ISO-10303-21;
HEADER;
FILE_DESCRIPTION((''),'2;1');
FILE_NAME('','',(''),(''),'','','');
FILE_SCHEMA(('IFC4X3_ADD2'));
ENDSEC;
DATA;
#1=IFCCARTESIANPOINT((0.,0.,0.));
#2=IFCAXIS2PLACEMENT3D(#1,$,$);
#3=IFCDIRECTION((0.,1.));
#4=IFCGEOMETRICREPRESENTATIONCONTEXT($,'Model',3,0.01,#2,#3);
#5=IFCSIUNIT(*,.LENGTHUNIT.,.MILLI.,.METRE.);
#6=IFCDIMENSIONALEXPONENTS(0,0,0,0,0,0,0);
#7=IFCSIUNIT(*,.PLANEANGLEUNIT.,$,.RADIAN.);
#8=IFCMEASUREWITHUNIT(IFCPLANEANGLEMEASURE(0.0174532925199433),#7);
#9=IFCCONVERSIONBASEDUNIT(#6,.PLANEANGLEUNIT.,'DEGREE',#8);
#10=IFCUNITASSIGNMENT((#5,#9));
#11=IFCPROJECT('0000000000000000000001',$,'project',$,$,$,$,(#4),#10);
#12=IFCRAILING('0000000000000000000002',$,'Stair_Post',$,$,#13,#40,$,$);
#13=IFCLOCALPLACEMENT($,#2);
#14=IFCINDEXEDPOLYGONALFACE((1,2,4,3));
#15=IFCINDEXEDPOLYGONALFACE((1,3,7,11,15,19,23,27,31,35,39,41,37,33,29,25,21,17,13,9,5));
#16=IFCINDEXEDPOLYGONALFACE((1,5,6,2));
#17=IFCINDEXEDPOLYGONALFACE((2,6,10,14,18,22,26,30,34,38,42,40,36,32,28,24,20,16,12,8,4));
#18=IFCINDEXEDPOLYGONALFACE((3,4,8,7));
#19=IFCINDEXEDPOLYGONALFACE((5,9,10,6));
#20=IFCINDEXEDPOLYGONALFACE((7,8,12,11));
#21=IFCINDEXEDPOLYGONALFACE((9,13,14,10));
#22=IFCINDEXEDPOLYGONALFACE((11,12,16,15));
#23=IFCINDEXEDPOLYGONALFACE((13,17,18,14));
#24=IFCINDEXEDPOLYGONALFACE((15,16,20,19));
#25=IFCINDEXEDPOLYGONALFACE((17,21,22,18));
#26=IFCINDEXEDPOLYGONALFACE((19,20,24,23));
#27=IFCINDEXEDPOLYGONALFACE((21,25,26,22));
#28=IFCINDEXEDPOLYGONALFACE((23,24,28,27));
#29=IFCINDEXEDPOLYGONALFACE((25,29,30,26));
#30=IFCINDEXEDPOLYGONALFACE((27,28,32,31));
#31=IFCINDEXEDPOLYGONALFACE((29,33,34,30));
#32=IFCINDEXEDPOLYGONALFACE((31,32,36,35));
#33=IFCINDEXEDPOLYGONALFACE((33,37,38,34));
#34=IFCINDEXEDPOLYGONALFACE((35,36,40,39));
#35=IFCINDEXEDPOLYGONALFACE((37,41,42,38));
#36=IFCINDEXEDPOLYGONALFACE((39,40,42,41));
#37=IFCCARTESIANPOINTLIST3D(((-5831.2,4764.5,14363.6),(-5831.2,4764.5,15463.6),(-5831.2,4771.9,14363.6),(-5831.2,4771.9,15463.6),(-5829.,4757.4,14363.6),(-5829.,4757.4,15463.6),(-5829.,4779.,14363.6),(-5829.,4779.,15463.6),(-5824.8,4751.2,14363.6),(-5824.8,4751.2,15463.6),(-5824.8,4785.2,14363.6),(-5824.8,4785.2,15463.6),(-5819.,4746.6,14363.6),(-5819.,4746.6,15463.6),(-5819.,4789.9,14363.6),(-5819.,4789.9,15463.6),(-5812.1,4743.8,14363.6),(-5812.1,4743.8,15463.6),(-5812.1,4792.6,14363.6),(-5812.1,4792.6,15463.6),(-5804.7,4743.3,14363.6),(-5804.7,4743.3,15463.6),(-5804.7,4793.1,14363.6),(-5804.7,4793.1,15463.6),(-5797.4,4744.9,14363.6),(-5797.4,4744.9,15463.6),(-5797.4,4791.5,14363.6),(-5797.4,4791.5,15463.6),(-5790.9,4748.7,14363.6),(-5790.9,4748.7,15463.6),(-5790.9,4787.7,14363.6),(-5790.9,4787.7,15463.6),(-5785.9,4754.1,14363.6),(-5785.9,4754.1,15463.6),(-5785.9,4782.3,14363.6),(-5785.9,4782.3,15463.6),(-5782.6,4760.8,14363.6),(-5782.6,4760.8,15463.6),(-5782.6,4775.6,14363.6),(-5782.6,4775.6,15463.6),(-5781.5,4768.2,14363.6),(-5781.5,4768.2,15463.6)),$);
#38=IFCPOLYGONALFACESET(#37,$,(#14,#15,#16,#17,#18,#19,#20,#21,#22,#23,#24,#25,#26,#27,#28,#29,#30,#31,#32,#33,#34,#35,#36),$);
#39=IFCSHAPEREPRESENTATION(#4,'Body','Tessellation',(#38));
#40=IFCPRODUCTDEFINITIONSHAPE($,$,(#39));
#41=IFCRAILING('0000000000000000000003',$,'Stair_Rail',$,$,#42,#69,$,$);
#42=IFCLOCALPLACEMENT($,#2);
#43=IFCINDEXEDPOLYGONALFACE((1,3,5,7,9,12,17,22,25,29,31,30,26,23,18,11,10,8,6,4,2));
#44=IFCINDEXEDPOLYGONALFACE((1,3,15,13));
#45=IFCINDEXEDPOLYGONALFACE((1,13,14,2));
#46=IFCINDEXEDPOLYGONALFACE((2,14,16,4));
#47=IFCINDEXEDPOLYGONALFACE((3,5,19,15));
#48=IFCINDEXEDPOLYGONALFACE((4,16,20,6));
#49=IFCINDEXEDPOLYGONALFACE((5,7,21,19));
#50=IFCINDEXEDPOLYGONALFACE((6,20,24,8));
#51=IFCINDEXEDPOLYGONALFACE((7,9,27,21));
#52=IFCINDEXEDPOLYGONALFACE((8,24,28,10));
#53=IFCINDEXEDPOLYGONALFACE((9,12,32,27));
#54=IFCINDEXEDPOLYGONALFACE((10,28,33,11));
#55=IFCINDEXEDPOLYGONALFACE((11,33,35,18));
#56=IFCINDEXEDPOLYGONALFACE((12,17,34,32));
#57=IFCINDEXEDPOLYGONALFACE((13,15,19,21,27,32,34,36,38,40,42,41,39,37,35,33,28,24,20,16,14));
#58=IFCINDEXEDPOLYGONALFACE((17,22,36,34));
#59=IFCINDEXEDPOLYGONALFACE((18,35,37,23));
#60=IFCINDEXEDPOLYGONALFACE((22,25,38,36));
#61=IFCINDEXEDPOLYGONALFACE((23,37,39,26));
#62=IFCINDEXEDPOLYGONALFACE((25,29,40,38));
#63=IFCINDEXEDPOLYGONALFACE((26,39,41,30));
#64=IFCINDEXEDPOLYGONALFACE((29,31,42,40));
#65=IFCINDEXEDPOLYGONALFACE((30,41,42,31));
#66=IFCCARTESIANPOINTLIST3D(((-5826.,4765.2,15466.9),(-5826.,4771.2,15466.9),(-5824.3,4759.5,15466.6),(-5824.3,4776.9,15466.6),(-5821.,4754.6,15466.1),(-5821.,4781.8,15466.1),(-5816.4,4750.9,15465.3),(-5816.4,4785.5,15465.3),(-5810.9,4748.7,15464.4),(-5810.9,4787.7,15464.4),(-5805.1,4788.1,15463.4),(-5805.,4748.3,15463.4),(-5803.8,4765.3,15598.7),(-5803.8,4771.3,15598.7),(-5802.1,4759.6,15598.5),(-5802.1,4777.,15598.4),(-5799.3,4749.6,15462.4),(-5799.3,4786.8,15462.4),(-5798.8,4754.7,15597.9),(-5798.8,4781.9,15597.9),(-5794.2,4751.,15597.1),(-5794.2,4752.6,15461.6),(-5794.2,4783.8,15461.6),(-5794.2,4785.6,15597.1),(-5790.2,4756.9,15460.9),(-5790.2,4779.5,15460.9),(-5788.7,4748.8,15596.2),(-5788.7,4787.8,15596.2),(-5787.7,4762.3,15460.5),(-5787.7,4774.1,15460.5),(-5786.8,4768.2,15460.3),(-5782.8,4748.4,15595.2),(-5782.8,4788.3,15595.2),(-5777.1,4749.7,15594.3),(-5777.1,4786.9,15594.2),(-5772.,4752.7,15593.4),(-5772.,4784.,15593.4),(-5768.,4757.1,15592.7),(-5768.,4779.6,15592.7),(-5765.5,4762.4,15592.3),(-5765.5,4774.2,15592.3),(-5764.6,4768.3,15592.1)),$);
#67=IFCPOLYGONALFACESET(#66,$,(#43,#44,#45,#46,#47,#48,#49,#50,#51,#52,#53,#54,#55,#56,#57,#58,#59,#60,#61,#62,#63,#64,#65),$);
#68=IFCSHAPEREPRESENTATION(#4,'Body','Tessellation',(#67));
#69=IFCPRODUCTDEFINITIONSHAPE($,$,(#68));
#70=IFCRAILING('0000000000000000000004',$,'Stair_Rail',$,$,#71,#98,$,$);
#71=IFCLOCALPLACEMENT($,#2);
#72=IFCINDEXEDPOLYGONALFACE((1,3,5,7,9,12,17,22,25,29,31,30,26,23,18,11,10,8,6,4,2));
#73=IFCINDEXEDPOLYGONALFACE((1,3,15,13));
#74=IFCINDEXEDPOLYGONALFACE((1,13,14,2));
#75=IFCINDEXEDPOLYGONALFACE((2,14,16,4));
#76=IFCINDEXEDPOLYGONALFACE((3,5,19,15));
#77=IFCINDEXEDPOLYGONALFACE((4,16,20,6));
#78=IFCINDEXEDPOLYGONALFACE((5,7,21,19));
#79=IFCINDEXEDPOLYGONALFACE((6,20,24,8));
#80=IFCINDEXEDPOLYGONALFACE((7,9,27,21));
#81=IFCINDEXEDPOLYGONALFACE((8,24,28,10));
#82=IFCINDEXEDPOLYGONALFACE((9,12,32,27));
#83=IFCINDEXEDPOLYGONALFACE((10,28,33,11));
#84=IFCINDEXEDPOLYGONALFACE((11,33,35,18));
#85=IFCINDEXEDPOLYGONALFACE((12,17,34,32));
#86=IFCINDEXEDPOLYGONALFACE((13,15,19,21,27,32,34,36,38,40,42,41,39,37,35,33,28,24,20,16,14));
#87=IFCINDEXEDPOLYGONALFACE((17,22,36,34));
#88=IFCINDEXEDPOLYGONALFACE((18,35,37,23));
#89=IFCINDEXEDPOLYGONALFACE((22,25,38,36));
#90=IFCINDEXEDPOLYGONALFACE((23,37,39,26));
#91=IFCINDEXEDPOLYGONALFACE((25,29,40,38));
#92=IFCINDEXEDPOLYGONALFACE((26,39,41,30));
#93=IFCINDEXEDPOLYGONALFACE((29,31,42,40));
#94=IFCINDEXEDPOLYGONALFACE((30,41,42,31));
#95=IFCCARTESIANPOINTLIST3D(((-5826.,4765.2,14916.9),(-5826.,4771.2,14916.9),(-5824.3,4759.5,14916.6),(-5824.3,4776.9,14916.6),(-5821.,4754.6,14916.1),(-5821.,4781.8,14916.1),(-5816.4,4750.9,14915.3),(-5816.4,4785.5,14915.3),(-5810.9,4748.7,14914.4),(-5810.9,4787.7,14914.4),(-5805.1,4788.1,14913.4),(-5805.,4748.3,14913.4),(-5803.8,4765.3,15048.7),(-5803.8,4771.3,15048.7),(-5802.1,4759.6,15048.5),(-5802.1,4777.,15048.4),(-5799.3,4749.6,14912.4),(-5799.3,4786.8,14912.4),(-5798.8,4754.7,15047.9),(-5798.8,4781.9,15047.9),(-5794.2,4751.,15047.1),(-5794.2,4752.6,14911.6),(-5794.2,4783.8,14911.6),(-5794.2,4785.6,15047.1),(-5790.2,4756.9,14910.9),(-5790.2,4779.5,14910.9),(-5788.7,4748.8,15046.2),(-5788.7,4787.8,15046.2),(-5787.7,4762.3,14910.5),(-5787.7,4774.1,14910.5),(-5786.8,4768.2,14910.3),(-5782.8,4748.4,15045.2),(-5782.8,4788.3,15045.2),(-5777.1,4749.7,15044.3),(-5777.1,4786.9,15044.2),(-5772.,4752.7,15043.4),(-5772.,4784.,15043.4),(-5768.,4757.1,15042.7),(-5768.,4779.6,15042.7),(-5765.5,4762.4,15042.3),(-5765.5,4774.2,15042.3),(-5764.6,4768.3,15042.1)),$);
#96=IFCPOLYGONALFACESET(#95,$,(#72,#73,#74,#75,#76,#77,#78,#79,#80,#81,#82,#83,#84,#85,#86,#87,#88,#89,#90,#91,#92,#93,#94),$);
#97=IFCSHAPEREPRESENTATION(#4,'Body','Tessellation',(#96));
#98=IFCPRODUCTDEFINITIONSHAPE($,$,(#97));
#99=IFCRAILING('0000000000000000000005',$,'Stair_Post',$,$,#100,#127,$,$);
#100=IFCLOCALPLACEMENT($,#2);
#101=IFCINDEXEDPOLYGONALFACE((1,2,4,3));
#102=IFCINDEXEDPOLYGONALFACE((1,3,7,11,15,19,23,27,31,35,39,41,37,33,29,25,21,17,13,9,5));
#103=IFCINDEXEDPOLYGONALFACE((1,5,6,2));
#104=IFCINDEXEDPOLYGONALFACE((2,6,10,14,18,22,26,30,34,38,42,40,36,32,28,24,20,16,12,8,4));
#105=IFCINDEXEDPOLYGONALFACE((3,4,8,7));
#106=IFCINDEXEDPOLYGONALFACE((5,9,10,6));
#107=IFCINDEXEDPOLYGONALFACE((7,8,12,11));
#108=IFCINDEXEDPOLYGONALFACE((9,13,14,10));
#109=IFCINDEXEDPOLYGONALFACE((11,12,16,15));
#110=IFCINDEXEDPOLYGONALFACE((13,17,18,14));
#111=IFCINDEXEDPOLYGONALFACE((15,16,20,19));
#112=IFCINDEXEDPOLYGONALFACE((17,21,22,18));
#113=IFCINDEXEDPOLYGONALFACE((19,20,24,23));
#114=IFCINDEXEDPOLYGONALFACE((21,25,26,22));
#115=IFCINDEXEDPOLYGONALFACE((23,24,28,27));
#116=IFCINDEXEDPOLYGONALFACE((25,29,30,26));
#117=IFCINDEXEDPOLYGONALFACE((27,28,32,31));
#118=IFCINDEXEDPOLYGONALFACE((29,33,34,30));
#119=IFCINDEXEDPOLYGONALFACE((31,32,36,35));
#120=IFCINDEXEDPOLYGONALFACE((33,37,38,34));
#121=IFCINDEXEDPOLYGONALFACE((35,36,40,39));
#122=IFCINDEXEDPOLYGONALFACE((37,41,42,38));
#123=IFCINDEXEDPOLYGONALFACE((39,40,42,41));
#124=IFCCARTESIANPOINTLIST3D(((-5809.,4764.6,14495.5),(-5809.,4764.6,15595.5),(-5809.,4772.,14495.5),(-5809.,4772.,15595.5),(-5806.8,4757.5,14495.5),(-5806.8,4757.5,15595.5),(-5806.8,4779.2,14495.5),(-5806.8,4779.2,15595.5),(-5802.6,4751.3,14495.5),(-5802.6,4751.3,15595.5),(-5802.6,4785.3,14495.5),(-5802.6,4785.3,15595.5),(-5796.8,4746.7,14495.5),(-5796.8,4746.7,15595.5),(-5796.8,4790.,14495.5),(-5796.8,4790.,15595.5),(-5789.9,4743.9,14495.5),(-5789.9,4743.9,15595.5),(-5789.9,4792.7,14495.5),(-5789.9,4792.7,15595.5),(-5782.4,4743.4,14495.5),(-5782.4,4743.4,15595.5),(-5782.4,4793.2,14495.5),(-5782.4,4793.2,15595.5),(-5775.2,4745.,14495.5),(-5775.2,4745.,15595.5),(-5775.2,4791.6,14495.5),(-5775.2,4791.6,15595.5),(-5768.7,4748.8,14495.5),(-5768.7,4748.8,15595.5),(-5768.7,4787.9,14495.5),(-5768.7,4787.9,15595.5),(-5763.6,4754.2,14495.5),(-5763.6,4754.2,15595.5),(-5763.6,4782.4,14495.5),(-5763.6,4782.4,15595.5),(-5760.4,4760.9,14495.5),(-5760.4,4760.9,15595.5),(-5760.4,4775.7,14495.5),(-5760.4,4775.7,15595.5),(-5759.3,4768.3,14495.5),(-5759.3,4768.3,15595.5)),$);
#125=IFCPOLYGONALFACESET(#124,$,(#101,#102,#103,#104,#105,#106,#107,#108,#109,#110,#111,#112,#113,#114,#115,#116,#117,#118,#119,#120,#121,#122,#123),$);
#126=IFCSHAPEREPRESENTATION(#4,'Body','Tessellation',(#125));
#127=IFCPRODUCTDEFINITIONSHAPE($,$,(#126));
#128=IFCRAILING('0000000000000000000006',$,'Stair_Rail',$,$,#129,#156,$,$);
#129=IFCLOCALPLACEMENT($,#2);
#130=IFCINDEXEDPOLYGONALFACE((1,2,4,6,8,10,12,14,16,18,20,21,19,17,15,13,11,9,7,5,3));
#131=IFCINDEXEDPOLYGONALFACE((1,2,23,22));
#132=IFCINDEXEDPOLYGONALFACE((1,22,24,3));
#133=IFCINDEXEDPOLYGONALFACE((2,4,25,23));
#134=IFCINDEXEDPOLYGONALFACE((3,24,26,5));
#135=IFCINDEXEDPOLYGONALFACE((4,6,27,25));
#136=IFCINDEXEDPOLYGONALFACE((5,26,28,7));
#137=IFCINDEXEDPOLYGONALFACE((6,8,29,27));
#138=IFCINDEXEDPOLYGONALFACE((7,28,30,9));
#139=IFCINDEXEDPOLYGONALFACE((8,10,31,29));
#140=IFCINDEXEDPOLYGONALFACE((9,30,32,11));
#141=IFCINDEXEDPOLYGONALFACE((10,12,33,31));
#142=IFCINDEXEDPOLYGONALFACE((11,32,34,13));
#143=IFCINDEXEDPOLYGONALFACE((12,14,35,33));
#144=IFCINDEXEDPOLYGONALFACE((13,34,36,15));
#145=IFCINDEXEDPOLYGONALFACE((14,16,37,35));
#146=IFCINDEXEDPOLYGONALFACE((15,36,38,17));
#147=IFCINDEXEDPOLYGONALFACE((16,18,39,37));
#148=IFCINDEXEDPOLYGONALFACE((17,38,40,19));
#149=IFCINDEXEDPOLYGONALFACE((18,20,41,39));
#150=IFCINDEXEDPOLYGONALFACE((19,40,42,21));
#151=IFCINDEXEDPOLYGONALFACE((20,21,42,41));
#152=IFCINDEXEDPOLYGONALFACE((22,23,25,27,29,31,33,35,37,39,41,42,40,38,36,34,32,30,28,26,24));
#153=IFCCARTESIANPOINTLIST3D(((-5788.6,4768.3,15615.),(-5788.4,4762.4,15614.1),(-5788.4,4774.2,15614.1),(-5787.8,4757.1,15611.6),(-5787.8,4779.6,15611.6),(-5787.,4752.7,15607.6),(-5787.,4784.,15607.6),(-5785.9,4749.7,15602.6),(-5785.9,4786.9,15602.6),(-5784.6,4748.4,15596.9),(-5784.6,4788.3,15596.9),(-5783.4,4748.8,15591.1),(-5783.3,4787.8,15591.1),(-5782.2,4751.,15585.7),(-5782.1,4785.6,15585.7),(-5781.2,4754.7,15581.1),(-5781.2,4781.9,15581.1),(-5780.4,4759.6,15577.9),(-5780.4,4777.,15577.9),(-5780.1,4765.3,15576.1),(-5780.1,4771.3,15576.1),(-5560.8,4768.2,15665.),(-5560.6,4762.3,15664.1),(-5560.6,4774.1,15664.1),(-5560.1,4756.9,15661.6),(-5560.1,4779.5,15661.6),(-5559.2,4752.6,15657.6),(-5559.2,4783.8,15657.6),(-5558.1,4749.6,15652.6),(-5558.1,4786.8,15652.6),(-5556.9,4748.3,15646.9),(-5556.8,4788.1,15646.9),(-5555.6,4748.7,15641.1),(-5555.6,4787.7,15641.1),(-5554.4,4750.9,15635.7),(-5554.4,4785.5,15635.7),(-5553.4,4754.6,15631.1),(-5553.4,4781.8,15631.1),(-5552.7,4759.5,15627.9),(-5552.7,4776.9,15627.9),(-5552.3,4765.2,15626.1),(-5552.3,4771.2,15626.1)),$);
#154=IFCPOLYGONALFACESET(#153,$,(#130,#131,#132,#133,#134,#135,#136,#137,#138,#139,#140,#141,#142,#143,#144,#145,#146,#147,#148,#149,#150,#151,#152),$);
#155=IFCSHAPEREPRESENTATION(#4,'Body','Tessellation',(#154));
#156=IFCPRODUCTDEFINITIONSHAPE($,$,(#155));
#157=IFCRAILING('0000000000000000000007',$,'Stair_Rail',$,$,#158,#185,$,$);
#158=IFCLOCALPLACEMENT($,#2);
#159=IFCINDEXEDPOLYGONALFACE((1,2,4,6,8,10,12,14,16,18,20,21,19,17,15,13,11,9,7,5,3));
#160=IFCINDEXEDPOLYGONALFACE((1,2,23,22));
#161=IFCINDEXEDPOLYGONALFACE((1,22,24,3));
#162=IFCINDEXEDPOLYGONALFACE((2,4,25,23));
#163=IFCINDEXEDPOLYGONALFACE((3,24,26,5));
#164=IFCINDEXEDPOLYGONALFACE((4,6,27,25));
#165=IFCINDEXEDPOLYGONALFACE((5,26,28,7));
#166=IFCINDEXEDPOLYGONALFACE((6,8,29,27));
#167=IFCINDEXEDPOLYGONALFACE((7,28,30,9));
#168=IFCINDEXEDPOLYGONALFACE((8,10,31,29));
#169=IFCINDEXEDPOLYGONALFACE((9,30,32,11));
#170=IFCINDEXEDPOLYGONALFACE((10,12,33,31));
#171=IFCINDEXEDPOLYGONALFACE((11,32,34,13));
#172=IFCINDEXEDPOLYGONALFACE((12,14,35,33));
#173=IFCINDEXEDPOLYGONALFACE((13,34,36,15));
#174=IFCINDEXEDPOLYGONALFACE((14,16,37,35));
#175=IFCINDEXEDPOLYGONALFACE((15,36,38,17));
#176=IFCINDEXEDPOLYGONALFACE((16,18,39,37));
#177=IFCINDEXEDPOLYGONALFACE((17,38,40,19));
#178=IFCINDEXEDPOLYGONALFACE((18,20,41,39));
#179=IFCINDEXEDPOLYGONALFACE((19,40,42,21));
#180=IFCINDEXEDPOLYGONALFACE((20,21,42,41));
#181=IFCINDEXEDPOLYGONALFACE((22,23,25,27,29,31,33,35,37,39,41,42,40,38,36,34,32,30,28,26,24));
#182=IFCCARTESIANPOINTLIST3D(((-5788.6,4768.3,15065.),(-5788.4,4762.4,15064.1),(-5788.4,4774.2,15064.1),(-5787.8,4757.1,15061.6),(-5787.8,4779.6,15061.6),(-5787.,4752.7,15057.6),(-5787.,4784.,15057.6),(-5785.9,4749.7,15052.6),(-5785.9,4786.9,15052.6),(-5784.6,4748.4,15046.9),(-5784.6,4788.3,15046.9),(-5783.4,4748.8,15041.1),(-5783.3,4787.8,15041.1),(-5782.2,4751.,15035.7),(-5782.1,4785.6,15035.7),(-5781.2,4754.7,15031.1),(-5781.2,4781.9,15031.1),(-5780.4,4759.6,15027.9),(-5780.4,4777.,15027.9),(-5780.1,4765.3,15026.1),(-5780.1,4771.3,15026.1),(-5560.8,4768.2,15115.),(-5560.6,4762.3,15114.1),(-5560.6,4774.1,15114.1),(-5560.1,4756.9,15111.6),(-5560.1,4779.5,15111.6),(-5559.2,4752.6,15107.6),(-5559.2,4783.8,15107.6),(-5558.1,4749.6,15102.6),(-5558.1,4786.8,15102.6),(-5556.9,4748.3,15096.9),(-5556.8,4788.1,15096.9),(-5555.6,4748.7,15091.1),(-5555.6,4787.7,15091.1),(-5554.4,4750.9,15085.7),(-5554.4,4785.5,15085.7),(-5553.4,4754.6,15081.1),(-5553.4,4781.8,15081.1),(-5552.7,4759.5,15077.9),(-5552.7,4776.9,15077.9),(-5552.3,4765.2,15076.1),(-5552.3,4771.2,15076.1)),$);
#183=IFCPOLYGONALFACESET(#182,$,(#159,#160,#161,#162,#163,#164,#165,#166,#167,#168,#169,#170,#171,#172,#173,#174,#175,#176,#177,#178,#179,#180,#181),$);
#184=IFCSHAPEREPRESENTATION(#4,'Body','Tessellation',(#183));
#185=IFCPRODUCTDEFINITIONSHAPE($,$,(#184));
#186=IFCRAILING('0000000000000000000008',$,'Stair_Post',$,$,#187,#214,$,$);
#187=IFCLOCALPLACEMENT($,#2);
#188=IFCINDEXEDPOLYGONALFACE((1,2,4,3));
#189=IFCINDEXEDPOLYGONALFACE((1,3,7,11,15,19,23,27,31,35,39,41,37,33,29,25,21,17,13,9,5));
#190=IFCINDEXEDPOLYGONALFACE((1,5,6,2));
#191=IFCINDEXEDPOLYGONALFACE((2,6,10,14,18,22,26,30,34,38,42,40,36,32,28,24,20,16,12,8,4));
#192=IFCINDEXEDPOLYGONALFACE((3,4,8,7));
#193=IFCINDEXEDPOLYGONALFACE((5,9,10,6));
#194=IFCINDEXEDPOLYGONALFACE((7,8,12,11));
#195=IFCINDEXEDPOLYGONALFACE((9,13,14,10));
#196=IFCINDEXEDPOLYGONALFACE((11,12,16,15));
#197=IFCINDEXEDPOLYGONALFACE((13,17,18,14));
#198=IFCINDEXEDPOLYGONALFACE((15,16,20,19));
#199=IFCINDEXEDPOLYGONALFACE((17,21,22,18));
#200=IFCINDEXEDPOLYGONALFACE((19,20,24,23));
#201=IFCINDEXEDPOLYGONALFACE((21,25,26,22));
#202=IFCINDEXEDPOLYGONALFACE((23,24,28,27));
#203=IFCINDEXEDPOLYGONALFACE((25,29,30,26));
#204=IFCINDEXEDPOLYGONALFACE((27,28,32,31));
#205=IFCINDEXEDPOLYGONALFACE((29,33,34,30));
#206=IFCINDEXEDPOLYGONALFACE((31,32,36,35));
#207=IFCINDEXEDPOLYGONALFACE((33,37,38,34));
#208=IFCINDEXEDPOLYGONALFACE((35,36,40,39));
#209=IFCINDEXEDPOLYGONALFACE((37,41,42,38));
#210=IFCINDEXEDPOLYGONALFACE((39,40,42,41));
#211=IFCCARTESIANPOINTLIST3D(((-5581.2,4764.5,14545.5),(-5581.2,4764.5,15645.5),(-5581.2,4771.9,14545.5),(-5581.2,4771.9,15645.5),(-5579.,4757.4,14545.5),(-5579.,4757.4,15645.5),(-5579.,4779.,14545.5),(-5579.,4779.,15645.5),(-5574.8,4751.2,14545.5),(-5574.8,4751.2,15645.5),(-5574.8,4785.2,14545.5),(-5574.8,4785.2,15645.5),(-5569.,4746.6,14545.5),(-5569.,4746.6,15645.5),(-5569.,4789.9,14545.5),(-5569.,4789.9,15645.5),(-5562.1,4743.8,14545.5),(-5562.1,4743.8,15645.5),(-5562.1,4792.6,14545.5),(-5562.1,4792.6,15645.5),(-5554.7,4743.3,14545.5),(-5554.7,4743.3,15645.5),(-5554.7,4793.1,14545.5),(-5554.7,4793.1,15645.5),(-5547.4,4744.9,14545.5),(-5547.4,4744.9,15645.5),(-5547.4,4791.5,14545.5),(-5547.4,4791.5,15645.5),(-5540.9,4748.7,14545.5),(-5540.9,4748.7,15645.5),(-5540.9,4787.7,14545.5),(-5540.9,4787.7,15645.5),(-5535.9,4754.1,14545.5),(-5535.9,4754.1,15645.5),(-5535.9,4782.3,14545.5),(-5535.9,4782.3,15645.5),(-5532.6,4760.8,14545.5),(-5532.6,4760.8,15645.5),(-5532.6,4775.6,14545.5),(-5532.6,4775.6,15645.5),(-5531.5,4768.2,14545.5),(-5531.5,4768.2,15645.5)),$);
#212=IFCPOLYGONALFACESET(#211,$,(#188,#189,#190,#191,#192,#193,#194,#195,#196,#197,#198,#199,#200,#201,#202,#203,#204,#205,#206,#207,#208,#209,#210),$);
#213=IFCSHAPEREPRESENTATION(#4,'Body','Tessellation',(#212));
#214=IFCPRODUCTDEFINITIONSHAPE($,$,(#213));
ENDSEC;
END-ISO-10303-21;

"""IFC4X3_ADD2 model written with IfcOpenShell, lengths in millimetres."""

from ifc_helpers import new_model, entity, si_unit, converted_unit, direction, frame, origin, context, project, circle, extrude, element, save


model = new_model("IFC4X3_ADD2")

# Units and contexts
model_context = context("Model", 3, precision=0.01, world=origin(), true_north=direction((0.0, 1.0)))
ifc_project = project(units=[si_unit("LENGTHUNIT", "METRE", prefix="MILLI"), converted_unit("PLANEANGLEUNIT", "DEGREE", entity("IfcPlaneAngleMeasure", 0.0174532925199433), si_unit("PLANEANGLEUNIT", "RADIAN"), dimensions=[0, 0, 0, 0, 0, 0, 0])], contexts=[model_context])

# Railings
element("IfcRailing", 1, Name="Stair_Post", context=model_context, shape_type="SweptSolid", body=[
    extrude(circle(Radius=25.0), frame((-5806.5, 4768.2, 14363.6)), (0.0, 0.0, 1.0), 1100.0),
])
element("IfcRailing", 2, Name="Stair_Rail", context=model_context, shape_type="SweptSolid", body=[
    entity("IfcSweptDiskSolid", entity("IfcPolyline", [entity("IfcCartesianPoint", [-5806.5, 4768.2, 15463.6]), entity("IfcCartesianPoint", [-5784.3, 4768.3, 15595.5])]), 20.0),
])
element("IfcRailing", 3, Name="Stair_Rail", context=model_context, shape_type="SweptSolid", body=[
    entity("IfcSweptDiskSolid", entity("IfcPolyline", [entity("IfcCartesianPoint", [-5806.5, 4768.2, 14913.6]), entity("IfcCartesianPoint", [-5784.3, 4768.3, 15045.5])]), 20.0),
])
element("IfcRailing", 4, Name="Stair_Post", context=model_context, shape_type="SweptSolid", body=[
    extrude(circle(Radius=25.0), frame((-5784.3, 4768.3, 14495.5)), (0.0, 0.0, 1.0), 1100.0),
])
element("IfcRailing", 5, Name="Stair_Rail", context=model_context, shape_type="SweptSolid", body=[
    entity("IfcSweptDiskSolid", entity("IfcPolyline", [entity("IfcCartesianPoint", [-5784.3, 4768.3, 15595.5]), entity("IfcCartesianPoint", [-5556.5, 4768.2, 15645.5])]), 20.0),
])
element("IfcRailing", 6, Name="Stair_Rail", context=model_context, shape_type="SweptSolid", body=[
    entity("IfcSweptDiskSolid", entity("IfcPolyline", [entity("IfcCartesianPoint", [-5784.3, 4768.3, 15045.5]), entity("IfcCartesianPoint", [-5556.5, 4768.2, 15095.5])]), 20.0),
])
element("IfcRailing", 7, Name="Stair_Post", context=model_context, shape_type="SweptSolid", body=[
    extrude(circle(Radius=25.0), frame((-5556.5, 4768.2, 14545.5)), (0.0, 0.0, 1.0), 1100.0),
])

save(model, "model.ifc")
